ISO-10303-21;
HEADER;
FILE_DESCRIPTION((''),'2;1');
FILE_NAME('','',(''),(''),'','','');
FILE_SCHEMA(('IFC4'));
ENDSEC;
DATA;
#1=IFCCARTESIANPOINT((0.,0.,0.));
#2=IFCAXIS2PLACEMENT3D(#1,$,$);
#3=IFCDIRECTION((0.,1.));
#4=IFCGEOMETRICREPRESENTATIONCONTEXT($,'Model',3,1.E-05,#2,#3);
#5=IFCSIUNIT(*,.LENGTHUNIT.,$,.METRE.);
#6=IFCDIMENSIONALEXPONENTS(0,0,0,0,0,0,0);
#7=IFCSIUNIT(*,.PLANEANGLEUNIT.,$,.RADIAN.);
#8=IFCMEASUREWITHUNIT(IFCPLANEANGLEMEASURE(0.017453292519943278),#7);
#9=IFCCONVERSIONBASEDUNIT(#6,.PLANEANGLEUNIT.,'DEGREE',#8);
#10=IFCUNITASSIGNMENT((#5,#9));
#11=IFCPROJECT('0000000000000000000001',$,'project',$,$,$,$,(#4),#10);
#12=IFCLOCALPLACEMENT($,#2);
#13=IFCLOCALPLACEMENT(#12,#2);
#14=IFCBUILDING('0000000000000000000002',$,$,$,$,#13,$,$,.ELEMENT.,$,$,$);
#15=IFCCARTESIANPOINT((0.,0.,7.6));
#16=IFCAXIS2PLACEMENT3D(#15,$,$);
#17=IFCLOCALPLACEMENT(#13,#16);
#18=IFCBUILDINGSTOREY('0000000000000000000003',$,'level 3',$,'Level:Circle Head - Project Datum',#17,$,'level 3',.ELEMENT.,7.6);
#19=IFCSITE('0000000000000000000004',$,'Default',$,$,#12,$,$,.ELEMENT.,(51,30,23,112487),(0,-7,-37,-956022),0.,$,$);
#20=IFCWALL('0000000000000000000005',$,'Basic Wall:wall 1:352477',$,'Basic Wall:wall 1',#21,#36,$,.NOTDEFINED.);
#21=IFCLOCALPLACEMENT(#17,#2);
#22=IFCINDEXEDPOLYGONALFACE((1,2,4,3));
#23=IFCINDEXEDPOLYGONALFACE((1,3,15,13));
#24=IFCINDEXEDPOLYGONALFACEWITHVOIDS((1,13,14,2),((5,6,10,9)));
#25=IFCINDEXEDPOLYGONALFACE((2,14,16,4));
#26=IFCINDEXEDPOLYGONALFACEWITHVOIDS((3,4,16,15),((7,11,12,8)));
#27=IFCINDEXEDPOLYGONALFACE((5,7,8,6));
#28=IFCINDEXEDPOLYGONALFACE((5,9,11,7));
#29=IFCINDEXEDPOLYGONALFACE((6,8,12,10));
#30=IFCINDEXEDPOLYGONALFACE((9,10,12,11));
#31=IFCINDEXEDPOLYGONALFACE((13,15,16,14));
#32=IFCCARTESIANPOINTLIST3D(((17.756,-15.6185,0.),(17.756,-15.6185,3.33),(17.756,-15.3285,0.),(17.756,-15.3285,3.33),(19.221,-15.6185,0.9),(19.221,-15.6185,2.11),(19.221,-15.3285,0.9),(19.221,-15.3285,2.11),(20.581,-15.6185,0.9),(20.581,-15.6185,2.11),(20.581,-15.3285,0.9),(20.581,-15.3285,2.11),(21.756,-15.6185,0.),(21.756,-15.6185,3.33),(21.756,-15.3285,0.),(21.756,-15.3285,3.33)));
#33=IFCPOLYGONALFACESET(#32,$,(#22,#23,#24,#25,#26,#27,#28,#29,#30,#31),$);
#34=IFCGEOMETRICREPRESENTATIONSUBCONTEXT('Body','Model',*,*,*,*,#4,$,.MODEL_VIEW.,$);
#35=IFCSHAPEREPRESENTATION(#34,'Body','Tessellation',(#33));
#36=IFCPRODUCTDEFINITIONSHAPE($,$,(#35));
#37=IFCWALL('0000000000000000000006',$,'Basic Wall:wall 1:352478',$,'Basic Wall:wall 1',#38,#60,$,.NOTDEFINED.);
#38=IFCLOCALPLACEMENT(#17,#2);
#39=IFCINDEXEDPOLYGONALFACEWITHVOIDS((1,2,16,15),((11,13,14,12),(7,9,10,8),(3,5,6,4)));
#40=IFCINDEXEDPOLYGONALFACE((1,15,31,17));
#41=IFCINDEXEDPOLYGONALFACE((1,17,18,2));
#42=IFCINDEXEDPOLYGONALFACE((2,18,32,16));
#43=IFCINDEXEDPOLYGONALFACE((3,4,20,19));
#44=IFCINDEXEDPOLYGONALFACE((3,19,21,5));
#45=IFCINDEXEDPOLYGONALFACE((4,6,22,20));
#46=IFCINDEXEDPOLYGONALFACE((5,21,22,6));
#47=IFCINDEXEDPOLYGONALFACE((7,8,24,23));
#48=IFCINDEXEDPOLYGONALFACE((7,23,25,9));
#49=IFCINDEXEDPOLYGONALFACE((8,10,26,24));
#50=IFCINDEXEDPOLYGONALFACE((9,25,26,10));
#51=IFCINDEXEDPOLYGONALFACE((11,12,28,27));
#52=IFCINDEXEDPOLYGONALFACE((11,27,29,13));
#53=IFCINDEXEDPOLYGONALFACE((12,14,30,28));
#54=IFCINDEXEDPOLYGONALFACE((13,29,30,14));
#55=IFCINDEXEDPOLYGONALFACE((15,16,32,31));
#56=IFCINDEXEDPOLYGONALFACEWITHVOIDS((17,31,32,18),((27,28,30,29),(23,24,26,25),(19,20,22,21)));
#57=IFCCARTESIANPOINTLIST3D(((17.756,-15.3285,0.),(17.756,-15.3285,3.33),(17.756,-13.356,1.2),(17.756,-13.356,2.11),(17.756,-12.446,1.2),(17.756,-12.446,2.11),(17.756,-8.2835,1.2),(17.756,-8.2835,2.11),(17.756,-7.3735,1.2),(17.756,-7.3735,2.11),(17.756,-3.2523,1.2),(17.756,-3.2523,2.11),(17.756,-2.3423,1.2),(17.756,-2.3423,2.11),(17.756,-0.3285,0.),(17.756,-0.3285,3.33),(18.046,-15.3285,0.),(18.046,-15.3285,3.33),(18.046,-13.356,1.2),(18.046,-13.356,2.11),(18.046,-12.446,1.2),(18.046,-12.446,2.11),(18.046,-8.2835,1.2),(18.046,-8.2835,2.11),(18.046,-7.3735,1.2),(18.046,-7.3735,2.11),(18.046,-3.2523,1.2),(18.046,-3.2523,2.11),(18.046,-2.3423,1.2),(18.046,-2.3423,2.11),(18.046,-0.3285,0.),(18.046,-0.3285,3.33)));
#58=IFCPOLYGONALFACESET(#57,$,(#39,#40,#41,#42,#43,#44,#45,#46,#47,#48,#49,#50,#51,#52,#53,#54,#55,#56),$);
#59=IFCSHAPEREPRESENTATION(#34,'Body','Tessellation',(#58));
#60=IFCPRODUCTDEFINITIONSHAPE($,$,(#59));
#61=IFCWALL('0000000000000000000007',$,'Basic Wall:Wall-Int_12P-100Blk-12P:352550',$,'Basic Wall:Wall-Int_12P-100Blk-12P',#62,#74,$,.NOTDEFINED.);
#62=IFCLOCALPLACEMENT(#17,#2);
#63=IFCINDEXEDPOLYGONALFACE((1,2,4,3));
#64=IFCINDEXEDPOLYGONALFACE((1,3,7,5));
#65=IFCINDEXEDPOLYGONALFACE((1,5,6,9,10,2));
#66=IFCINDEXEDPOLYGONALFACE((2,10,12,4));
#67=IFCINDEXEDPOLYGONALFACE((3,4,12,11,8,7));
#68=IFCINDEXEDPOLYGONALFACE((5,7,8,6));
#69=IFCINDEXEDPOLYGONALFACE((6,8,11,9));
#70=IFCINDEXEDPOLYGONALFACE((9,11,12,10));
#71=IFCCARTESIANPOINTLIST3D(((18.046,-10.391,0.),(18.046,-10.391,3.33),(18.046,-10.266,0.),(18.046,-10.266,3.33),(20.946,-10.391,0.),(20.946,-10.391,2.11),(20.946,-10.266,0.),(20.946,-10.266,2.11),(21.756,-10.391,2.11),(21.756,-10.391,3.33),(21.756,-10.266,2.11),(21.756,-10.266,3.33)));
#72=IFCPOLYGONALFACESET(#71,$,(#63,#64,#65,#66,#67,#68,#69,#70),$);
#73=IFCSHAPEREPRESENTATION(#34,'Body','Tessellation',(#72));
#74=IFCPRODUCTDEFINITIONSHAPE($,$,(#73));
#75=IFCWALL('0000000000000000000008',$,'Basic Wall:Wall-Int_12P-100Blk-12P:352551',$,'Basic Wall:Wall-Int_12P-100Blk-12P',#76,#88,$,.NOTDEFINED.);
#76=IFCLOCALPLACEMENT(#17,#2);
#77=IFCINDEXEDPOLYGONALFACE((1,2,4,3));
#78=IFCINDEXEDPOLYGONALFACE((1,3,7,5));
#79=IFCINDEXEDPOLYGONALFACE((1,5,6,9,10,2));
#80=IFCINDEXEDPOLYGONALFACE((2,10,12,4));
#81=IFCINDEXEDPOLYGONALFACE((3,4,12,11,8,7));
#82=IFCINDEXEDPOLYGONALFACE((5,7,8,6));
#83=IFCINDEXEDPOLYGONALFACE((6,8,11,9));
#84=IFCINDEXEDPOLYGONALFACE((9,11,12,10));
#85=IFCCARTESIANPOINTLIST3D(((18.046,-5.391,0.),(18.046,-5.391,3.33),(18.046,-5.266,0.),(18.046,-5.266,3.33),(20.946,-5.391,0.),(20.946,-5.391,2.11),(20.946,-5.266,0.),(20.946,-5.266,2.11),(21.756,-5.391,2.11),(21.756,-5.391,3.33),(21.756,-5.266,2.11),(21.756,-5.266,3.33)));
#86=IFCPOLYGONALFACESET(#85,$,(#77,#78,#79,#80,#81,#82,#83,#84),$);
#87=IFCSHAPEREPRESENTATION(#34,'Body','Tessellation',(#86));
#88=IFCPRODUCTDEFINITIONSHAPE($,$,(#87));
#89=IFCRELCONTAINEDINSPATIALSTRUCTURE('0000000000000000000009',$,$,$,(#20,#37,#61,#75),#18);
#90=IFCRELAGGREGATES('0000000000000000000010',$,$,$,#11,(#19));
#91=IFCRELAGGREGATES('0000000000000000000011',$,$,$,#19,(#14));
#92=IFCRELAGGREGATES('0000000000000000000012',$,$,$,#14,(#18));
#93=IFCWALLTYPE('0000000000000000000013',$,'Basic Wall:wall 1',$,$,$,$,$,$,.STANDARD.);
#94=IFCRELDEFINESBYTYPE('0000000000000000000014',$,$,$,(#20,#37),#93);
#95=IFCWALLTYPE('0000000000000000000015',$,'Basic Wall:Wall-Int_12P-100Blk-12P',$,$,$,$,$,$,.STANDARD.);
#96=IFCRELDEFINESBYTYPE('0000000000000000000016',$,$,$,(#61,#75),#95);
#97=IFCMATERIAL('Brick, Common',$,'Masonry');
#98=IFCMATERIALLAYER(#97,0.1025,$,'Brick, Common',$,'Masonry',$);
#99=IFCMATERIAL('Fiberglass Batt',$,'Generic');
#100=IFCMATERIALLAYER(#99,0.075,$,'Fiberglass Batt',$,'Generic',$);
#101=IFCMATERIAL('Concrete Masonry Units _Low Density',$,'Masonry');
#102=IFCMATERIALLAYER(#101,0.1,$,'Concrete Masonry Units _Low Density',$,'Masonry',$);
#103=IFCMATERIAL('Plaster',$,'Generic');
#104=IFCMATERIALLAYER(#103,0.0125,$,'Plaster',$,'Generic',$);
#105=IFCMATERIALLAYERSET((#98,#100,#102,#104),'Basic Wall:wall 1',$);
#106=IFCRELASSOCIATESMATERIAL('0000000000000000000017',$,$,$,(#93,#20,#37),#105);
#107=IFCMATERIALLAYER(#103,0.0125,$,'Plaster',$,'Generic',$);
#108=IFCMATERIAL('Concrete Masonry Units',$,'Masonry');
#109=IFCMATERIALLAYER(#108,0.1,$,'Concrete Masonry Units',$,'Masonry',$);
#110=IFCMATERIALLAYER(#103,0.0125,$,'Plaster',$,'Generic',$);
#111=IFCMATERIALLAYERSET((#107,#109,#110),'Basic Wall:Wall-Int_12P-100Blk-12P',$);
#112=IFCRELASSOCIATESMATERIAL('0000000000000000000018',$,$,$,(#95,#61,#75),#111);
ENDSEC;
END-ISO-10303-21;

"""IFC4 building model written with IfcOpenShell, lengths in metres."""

from ifc_helpers import new_model, entity, si_unit, converted_unit, direction, frame, frame_2d, origin, place, context, subcontext, project, spatial, polyline, rectangle, extrude, clip, bounded_halfspace, material, layer, layer_set, layer_usage, type_object, element, save


model = new_model("IFC4")

# Units and contexts
model_context = context("Model", 3, precision=1e-05, world=origin(), true_north=direction((0.0, 1.0)))
body_context = subcontext(model_context, "Body", "Model", "MODEL_VIEW")
ifc_project = project(units=[si_unit("LENGTHUNIT", "METRE"), converted_unit("PLANEANGLEUNIT", "DEGREE", entity("IfcPlaneAngleMeasure", 0.017453292519943278), si_unit("PLANEANGLEUNIT", "RADIAN"), dimensions=[0, 0, 0, 0, 0, 0, 0])], contexts=[model_context])

# Site, building, storey
site_placement = place(None, origin())
site = spatial("IfcSite", under=ifc_project, at=site_placement, Name="Default", CompositionType="ELEMENT", RefLatitude=(51, 30, 23, 112487), RefLongitude=(0, -7, -37, -956022), RefElevation=0.0)
building_placement = place(site_placement, origin())
building = spatial("IfcBuilding", under=site, at=building_placement, CompositionType="ELEMENT")
storey_placement = place(building_placement, frame((0.0, 0.0, 7.6)))
storey = spatial("IfcBuildingStorey", under=building, at=storey_placement, Name="level 3", ObjectType="Level:Circle Head - Project Datum", LongName="level 3", CompositionType="ELEMENT", Elevation=7.6)

# Wall, opening
ifc_material_1 = material(Name="Brick, Common", Category="Masonry")
ifc_layer_1 = layer(ifc_material_1, 0.1025, Name="Brick, Common", Category="Masonry")
ifc_material_2 = material(Name="Fiberglass Batt", Category="Generic")
ifc_layer_2 = layer(ifc_material_2, 0.075, Name="Fiberglass Batt", Category="Generic")
ifc_material_3 = material(Name="Concrete Masonry Units _Low Density", Category="Masonry")
ifc_layer_3 = layer(ifc_material_3, 0.1, Name="Concrete Masonry Units _Low Density", Category="Masonry")
ifc_material_4 = material(Name="Plaster", Category="Generic")
ifc_layer_4 = layer(ifc_material_4, 0.0125, Name="Plaster", Category="Generic")
ifc_layer_set_1 = layer_set([ifc_layer_1, ifc_layer_2, ifc_layer_3, ifc_layer_4], Name="Basic Wall:wall 1")
ifc_layer_usage_1 = layer_usage(ifc_layer_set_1, "AXIS2", "NEGATIVE", 0.145)
wall_type_1 = type_object("IfcWallType", Name="Basic Wall:wall 1", PredefinedType="STANDARD", material=ifc_layer_set_1)
wall_1_placement = place(storey_placement, frame((21.756, -15.4735, 0.0), z_axis=(0.0, 0.0, 1.0), x_axis=(-1.0, 0.0, 0.0)))
wall_1 = element("IfcWall", 1, at=wall_1_placement, inside=storey, type_object=wall_type_1, material=ifc_layer_usage_1, Name="Basic Wall:wall 1:352477", ObjectType="Basic Wall:wall 1", PredefinedType="NOTDEFINED", context=body_context, shape_type="Clipping", body=[
    clip(extrude(rectangle(XDim=4.0, YDim=0.29, at=frame_2d((2.0, 0.0), x_axis=(-1.0, 0.0))), origin(), (0.0, 0.0, 1.0), 3.33), bounded_halfspace(frame((0.0, -0.145, 3.33), z_axis=(0.0, 0.0, -1.0), x_axis=(0.0, -1.0, 0.0)), True, frame((0.0, -0.145, 3.33)), polyline([(0.0, 0.0), (3.71, 0.0), (4.0, 0.0), (4.0, 0.29), (0.0, 0.29), (0.0, 0.0)]))),
])
opening_1_placement = place(wall_1_placement, frame((1.175, -0.145, 0.9)))
element("IfcOpeningElement", 2, at=opening_1_placement, cuts=wall_1, PredefinedType="OPENING", context=body_context, shape_type="SweptSolid", body=[
    extrude(rectangle(XDim=1.21, YDim=1.36, at=frame_2d((0.605, 0.68), x_axis=(-1.0, 0.0))), frame((0.0, 0.0, 0.0), z_axis=(0.0, 1.0, 0.0), x_axis=(0.0, 0.0, 1.0)), (0.0, 0.0, 1.0), 0.29),
])

# Wall, openings
ifc_layer_usage_2 = layer_usage(ifc_layer_set_1, "AXIS2", "NEGATIVE", 0.145)
wall_2_placement = place(storey_placement, frame((17.901, -15.3285, 0.0), z_axis=(0.0, 0.0, 1.0), x_axis=(0.0, 1.0, 0.0)))
wall_2 = element("IfcWall", 3, at=wall_2_placement, inside=storey, type_object=wall_type_1, material=ifc_layer_usage_2, Name="Basic Wall:wall 1:352478", ObjectType="Basic Wall:wall 1", PredefinedType="NOTDEFINED", context=body_context, shape_type="Clipping", body=[
    clip(extrude(rectangle(XDim=15.0, YDim=0.29, at=frame_2d((7.5, 0.0), x_axis=(-1.0, 0.0))), origin(), (0.0, 0.0, 1.0), 3.33), bounded_halfspace(frame((0.0, -0.145, 3.33), z_axis=(0.0, 0.0, -1.0), x_axis=(1.0, 0.0, 0.0)), True, frame((0.0, -0.145, 3.33)), polyline([(0.0, 0.0), (4.9375, 0.0), (5.0625, 0.0), (9.9375, 0.0), (10.0625, 0.0), (15.0, 0.0), (15.0, 0.29), (14.855, 0.29), (0.0, 0.29), (0.0, 0.0)]))),
])
opening_2_placement = place(wall_2_placement, frame((1.9725, -0.145, 1.2)))
element("IfcOpeningElement", 4, at=opening_2_placement, cuts=wall_2, PredefinedType="OPENING", context=body_context, shape_type="SweptSolid", body=[
    extrude(rectangle(XDim=0.91, YDim=0.91, at=frame_2d((0.455, 0.455), x_axis=(-1.0, 0.0))), frame((0.0, 0.0, 0.0), z_axis=(0.0, 1.0, 0.0), x_axis=(0.0, 0.0, 1.0)), (0.0, 0.0, 1.0), 0.29),
])
opening_3_placement = place(wall_2_placement, frame((7.045, -0.145, 1.2)))
element("IfcOpeningElement", 5, at=opening_3_placement, cuts=wall_2, PredefinedType="OPENING", context=body_context, shape_type="SweptSolid", body=[
    extrude(rectangle(XDim=0.91, YDim=0.91, at=frame_2d((0.455, 0.455), x_axis=(-1.0, 0.0))), frame((0.0, 0.0, 0.0), z_axis=(0.0, 1.0, 0.0), x_axis=(0.0, 0.0, 1.0)), (0.0, 0.0, 1.0), 0.29),
])
opening_4_placement = place(wall_2_placement, frame((12.0763, -0.145, 1.2)))
element("IfcOpeningElement", 6, at=opening_4_placement, cuts=wall_2, PredefinedType="OPENING", context=body_context, shape_type="SweptSolid", body=[
    extrude(rectangle(XDim=0.91, YDim=0.91, at=frame_2d((0.455, 0.455), x_axis=(-1.0, 0.0))), frame((0.0, 0.0, 0.0), z_axis=(0.0, 1.0, 0.0), x_axis=(0.0, 0.0, 1.0)), (0.0, 0.0, 1.0), 0.29),
])

# Walls, openings
ifc_layer_5 = layer(ifc_material_4, 0.0125, Name="Plaster", Category="Generic")
ifc_material_5 = material(Name="Concrete Masonry Units", Category="Masonry")
ifc_layer_6 = layer(ifc_material_5, 0.1, Name="Concrete Masonry Units", Category="Masonry")
ifc_layer_7 = layer(ifc_material_4, 0.0125, Name="Plaster", Category="Generic")
ifc_layer_set_2 = layer_set([ifc_layer_5, ifc_layer_6, ifc_layer_7], Name="Basic Wall:Wall-Int_12P-100Blk-12P")
ifc_layer_usage_3 = layer_usage(ifc_layer_set_2, "AXIS2", "NEGATIVE", 0.0625)
wall_type_2 = type_object("IfcWallType", Name="Basic Wall:Wall-Int_12P-100Blk-12P", PredefinedType="STANDARD", material=ifc_layer_set_2)
wall_3_placement = place(storey_placement, frame((18.046, -10.3285, 0.0)))
wall_3 = element("IfcWall", 7, at=wall_3_placement, inside=storey, type_object=wall_type_2, material=ifc_layer_usage_3, Name="Basic Wall:Wall-Int_12P-100Blk-12P:352550", ObjectType="Basic Wall:Wall-Int_12P-100Blk-12P", PredefinedType="NOTDEFINED", context=body_context, shape_type="Clipping", body=[
    clip(extrude(rectangle(XDim=3.71, YDim=0.125, at=frame_2d((1.855, 0.0), x_axis=(-1.0, 0.0))), origin(), (0.0, 0.0, 1.0), 3.33), bounded_halfspace(frame((0.0, -0.0625, 3.33), z_axis=(0.0, 0.0, -1.0), x_axis=(0.0, 1.0, 0.0)), True, frame((0.0, -0.0625, 3.33)), polyline([(0.0, 0.0), (3.71, 0.0), (3.71, 0.125), (0.0, 0.125), (0.0, 0.0)]))),
])
opening_5_placement = place(wall_3_placement, frame((3.71, 0.0625, 0.0)))
element("IfcOpeningElement", 8, at=opening_5_placement, cuts=wall_3, PredefinedType="OPENING", context=body_context, shape_type="SweptSolid", body=[
    extrude(rectangle(XDim=2.11, YDim=0.81, at=frame_2d((1.055, 0.405), x_axis=(1.0, 0.0))), frame((0.0, 0.0, 0.0), z_axis=(0.0, -1.0, 0.0), x_axis=(0.0, 0.0, 1.0)), (0.0, 0.0, 1.0), 0.125),
])
ifc_layer_usage_4 = layer_usage(ifc_layer_set_2, "AXIS2", "NEGATIVE", 0.0625)
wall_4_placement = place(storey_placement, frame((18.046, -5.3285, 0.0)))
wall_4 = element("IfcWall", 9, at=wall_4_placement, inside=storey, type_object=wall_type_2, material=ifc_layer_usage_4, Name="Basic Wall:Wall-Int_12P-100Blk-12P:352551", ObjectType="Basic Wall:Wall-Int_12P-100Blk-12P", PredefinedType="NOTDEFINED", context=body_context, shape_type="Clipping", body=[
    clip(extrude(rectangle(XDim=3.71, YDim=0.125, at=frame_2d((1.855, 0.0), x_axis=(-1.0, 0.0))), origin(), (0.0, 0.0, 1.0), 3.33), bounded_halfspace(frame((0.0, -0.0625, 3.33), z_axis=(0.0, 0.0, -1.0), x_axis=(0.0, 1.0, 0.0)), True, frame((0.0, -0.0625, 3.33)), polyline([(0.0, 0.0), (3.71, 0.0), (3.71, 0.125), (0.0, 0.125), (0.0, 0.0)]))),
])
opening_6_placement = place(wall_4_placement, frame((3.71, 0.0625, 0.0)))
element("IfcOpeningElement", 10, at=opening_6_placement, cuts=wall_4, PredefinedType="OPENING", context=body_context, shape_type="SweptSolid", body=[
    extrude(rectangle(XDim=2.11, YDim=0.81, at=frame_2d((1.055, 0.405), x_axis=(1.0, 0.0))), frame((0.0, 0.0, 0.0), z_axis=(0.0, -1.0, 0.0), x_axis=(0.0, 0.0, 1.0)), (0.0, 0.0, 1.0), 0.125),
])

save(model, "model.ifc")
